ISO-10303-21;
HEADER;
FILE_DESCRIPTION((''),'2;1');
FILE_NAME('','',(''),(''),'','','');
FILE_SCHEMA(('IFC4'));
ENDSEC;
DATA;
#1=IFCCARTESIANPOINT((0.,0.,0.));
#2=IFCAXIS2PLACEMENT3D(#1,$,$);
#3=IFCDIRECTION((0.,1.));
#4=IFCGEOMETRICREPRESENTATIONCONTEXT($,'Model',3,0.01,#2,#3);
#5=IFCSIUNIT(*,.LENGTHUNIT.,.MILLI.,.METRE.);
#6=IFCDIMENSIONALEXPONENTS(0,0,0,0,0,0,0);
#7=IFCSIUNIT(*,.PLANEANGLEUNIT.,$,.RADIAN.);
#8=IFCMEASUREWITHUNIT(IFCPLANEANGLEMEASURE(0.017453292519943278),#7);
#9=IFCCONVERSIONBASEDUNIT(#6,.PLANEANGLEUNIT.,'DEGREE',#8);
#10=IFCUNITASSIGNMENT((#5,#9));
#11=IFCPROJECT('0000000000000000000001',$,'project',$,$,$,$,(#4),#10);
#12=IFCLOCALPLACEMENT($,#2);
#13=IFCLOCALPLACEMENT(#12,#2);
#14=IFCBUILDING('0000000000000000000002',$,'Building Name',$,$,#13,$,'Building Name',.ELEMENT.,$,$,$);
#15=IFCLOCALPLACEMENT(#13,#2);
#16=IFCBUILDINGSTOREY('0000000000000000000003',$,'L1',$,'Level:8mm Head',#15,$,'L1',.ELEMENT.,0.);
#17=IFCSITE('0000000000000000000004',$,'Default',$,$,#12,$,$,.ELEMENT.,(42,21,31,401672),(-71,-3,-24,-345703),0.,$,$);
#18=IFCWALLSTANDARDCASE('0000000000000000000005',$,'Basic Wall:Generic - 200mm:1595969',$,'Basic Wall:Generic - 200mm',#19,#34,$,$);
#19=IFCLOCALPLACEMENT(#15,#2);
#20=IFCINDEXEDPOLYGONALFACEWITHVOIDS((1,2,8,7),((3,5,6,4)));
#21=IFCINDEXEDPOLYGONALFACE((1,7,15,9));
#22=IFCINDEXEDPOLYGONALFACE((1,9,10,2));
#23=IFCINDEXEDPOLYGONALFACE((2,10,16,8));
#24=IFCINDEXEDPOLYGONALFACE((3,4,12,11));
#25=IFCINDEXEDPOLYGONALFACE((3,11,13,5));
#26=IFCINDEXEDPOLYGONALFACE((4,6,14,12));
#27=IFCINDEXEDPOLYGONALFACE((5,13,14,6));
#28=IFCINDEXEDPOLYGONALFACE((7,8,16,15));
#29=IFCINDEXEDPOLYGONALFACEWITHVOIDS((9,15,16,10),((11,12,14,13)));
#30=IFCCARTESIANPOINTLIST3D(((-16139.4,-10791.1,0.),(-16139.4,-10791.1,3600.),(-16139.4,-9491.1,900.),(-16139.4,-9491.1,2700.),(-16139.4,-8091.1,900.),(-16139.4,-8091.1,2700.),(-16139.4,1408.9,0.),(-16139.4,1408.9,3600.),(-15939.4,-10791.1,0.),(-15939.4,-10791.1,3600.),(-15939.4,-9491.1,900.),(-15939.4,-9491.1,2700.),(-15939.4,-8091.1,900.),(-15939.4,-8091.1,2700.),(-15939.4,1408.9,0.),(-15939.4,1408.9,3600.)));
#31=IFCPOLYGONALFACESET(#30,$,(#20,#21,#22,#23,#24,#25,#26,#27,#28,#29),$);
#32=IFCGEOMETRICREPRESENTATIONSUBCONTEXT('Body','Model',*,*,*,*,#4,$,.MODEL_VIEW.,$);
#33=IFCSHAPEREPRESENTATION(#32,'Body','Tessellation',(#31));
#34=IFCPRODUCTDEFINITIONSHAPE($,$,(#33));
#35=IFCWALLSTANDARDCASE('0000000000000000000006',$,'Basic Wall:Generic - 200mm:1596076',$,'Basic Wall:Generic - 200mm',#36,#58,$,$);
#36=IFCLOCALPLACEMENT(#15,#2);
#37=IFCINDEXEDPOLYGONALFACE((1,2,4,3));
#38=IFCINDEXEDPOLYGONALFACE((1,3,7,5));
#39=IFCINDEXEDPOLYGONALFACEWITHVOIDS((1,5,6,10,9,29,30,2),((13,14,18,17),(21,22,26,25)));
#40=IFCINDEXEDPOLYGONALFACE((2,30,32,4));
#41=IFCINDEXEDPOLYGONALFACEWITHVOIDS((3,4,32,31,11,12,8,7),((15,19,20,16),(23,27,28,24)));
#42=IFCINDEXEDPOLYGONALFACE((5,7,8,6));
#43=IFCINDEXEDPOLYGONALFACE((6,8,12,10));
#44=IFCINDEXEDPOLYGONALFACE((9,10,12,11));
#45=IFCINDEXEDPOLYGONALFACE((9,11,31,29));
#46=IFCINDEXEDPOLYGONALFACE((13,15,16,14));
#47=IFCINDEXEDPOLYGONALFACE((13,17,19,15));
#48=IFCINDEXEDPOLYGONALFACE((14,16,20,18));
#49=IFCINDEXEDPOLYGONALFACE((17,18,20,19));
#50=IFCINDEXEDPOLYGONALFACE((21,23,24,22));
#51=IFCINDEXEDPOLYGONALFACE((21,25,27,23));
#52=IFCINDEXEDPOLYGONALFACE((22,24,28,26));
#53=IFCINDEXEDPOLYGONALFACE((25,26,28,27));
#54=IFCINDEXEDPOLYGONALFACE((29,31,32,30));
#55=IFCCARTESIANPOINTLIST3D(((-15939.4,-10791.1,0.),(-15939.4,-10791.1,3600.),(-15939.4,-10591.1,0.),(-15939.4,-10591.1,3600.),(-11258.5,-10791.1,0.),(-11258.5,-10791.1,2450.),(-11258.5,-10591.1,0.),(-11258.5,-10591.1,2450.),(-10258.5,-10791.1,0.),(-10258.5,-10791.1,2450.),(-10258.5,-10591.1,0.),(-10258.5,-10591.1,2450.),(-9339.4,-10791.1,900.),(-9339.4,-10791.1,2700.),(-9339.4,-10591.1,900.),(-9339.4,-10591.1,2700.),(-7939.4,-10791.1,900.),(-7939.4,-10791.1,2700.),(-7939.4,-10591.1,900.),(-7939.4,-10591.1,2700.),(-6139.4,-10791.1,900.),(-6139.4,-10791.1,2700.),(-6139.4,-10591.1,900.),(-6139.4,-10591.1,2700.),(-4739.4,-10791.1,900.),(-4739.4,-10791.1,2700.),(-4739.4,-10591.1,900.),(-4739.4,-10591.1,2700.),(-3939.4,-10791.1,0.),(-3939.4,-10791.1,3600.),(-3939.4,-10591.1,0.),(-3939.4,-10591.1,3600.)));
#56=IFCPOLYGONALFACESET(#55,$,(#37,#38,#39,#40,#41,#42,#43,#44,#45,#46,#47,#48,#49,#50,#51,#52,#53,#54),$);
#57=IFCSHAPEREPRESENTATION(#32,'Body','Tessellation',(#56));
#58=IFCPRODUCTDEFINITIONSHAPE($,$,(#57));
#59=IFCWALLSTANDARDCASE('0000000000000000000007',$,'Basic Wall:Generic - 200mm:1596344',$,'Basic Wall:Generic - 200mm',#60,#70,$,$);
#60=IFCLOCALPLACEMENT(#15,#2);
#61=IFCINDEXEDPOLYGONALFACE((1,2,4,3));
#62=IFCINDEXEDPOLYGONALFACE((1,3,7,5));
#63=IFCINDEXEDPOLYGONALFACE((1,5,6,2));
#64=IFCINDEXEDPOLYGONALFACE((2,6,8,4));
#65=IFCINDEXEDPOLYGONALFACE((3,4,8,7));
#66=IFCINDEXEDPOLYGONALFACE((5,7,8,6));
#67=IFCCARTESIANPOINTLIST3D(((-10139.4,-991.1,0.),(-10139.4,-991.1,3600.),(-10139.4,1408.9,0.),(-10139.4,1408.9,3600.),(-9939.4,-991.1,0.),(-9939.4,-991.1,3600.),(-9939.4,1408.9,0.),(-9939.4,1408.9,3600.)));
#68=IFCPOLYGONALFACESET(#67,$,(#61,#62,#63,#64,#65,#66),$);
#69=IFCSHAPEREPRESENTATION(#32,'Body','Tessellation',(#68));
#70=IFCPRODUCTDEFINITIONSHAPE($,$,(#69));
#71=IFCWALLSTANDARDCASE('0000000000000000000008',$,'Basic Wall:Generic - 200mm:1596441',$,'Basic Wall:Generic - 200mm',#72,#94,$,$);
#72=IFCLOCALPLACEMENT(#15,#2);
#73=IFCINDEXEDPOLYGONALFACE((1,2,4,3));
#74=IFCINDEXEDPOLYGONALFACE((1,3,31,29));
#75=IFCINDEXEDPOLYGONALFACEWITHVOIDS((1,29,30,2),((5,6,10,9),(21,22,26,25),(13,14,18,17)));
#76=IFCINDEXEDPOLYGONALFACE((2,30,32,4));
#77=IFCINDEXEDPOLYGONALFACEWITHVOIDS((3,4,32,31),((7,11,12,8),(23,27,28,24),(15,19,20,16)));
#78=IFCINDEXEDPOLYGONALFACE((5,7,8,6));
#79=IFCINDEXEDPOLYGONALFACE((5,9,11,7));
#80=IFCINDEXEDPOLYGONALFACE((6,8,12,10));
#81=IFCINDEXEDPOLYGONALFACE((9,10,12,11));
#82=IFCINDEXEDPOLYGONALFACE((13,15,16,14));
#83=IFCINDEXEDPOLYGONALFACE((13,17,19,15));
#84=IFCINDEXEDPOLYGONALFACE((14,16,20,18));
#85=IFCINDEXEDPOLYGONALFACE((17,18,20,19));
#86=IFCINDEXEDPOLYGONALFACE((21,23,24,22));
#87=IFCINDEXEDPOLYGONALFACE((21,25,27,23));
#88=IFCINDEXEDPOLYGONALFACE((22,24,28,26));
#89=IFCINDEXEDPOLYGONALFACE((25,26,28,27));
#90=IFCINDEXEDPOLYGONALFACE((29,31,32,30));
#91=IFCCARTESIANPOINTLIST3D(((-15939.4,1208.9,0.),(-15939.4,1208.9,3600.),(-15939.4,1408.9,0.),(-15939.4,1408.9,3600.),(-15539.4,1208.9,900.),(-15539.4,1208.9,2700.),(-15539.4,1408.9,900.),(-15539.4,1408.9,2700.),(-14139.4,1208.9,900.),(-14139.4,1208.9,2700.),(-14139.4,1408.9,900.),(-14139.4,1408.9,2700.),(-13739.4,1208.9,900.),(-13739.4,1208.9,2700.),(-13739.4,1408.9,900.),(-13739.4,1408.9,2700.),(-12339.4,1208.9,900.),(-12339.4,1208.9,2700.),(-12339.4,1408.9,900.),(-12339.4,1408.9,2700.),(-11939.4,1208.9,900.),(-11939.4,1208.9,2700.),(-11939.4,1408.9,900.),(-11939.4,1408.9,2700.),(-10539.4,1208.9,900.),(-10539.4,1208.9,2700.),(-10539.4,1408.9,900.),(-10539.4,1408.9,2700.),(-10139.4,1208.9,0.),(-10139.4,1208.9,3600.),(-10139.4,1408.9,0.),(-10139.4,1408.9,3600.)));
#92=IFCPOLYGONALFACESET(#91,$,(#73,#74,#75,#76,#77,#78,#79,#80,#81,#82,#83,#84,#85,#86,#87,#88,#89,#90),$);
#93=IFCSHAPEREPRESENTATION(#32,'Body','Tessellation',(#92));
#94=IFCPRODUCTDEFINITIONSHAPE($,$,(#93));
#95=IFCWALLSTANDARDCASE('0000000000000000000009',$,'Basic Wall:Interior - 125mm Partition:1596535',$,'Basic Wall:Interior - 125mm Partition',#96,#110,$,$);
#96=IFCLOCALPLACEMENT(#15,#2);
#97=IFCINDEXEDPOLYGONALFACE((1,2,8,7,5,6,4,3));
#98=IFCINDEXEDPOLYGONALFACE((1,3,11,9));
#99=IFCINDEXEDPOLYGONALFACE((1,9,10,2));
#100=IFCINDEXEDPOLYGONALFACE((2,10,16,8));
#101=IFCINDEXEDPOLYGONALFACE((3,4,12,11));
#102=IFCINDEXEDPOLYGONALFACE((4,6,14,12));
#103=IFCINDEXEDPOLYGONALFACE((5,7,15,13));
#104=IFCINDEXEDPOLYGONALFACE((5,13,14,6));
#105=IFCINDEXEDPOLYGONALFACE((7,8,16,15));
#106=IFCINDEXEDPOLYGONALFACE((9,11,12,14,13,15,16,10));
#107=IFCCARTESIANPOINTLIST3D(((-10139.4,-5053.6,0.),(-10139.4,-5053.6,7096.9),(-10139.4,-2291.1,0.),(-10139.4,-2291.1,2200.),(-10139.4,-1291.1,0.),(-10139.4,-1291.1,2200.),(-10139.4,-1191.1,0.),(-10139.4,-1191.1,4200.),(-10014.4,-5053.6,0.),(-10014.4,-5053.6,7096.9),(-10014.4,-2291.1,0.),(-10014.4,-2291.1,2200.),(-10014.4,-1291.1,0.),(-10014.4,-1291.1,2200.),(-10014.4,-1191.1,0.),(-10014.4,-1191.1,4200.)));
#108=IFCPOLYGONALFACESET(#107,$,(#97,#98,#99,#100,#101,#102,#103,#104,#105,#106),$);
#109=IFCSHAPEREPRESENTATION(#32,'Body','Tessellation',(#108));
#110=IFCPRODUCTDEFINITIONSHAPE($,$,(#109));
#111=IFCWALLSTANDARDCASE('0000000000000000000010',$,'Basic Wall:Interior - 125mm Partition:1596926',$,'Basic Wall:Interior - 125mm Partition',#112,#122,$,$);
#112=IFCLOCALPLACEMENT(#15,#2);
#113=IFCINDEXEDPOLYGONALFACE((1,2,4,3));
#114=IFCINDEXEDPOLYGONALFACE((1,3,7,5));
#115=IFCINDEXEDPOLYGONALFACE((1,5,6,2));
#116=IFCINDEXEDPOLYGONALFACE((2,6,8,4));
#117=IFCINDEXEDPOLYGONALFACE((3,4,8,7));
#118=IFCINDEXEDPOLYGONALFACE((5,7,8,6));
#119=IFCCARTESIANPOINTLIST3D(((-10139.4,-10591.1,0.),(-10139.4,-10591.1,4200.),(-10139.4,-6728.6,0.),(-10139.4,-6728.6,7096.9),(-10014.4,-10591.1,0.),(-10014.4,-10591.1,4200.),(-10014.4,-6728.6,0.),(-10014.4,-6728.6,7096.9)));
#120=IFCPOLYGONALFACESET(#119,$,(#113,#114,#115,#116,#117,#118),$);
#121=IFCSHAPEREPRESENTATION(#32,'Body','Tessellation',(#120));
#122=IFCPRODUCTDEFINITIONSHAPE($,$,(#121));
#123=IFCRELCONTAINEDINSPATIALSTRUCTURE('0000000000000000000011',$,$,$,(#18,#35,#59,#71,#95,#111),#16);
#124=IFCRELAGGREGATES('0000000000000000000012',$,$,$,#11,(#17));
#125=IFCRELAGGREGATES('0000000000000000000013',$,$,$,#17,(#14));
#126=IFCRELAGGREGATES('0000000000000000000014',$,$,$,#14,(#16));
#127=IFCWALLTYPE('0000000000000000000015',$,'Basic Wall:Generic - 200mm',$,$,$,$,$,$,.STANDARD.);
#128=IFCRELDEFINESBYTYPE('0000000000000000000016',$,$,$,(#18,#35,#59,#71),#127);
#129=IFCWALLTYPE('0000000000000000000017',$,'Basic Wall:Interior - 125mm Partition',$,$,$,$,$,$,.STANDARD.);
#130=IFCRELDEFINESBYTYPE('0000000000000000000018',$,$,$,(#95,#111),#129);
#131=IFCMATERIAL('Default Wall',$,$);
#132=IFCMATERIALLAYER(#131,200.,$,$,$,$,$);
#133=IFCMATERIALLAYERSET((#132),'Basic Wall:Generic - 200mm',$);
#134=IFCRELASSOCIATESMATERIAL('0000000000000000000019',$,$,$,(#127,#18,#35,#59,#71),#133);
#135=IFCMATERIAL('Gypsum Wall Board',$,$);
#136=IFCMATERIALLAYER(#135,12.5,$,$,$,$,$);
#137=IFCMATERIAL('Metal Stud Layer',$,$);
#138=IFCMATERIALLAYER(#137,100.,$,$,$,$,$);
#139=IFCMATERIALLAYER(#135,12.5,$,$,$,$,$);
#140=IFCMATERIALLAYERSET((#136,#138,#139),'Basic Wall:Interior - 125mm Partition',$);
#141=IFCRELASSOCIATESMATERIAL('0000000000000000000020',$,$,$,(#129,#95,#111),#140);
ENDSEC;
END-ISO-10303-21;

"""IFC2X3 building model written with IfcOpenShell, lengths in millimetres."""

from ifc_helpers import new_model, entity, si_unit, converted_unit, direction, frame, frame_2d, origin, place, context, subcontext, project, spatial, polyline, rectangle, extrude, clip, bounded_halfspace, material, layer, layer_set, layer_usage, type_object, element, save


model = new_model("IFC2X3")

# Units and contexts
model_context = context("Model", 3, precision=0.01, world=origin(), true_north=direction((0.0, 1.0)))
body_context = subcontext(model_context, "Body", "Model", "MODEL_VIEW")
ifc_project = project(units=[si_unit("LENGTHUNIT", "METRE", prefix="MILLI"), converted_unit("PLANEANGLEUNIT", "DEGREE", entity("IfcPlaneAngleMeasure", 0.017453292519943278), si_unit("PLANEANGLEUNIT", "RADIAN"), dimensions=[0, 0, 0, 0, 0, 0, 0])], contexts=[model_context])

# Site, building, storey
site_placement = place(None, origin())
site = spatial("IfcSite", under=ifc_project, at=site_placement, Name="Default", CompositionType="ELEMENT", RefLatitude=(42, 21, 31, 401672), RefLongitude=(-71, -3, -24, -345703), RefElevation=0.0)
building_placement = place(site_placement, origin())
building = spatial("IfcBuilding", under=site, at=building_placement, Name="Building Name", LongName="Building Name", CompositionType="ELEMENT")
storey_placement = place(building_placement, origin())
storey = spatial("IfcBuildingStorey", under=building, at=storey_placement, Name="L1", ObjectType="Level:8mm Head", LongName="L1", CompositionType="ELEMENT", Elevation=0.0)

# Wall, opening
ifc_material_1 = material(Name="Default Wall")
ifc_layer_1 = layer(ifc_material_1, 200.0)
ifc_layer_set_1 = layer_set([ifc_layer_1], Name="Basic Wall:Generic - 200mm")
ifc_layer_usage_1 = layer_usage(ifc_layer_set_1, "AXIS2", "NEGATIVE", 100.0)
wall_type_1 = type_object("IfcWallType", Name="Basic Wall:Generic - 200mm", PredefinedType="STANDARD", material=ifc_layer_set_1)
wall_1_placement = place(storey_placement, frame((-16039.4, 1408.9, 0.0), z_axis=(0.0, 0.0, 1.0), x_axis=(0.0, -1.0, 0.0)))
wall_1 = element("IfcWallStandardCase", 1, at=wall_1_placement, inside=storey, type_object=wall_type_1, material=ifc_layer_usage_1, Name="Basic Wall:Generic - 200mm:1595969", ObjectType="Basic Wall:Generic - 200mm", context=body_context, shape_type="SweptSolid", body=[
    extrude(rectangle(XDim=12200.0, YDim=200.0, at=frame_2d((6100.0, 0.0), x_axis=(-1.0, 0.0))), origin(), (0.0, 0.0, 1.0), 3600.0),
])
opening_1_placement = place(wall_1_placement, frame((10900.0, 100.0, 900.0)))
element("IfcOpeningElement", 2, at=opening_1_placement, cuts=wall_1, ObjectType="Opening", context=body_context, shape_type="SweptSolid", body=[
    extrude(rectangle(XDim=1800.0, YDim=1400.0, at=frame_2d((900.0, 700.0), x_axis=(-1.0, 0.0))), frame((0.0, 0.0, 0.0), z_axis=(0.0, -1.0, 0.0), x_axis=(0.0, 0.0, 1.0)), (0.0, 0.0, 1.0), 200.0),
])

# Wall, openings
wall_2_placement = place(storey_placement, frame((-15939.4, -10691.1, 0.0)))
wall_2 = element("IfcWallStandardCase", 3, at=wall_2_placement, inside=storey, type_object=wall_type_1, material=ifc_layer_usage_1, Name="Basic Wall:Generic - 200mm:1596076", ObjectType="Basic Wall:Generic - 200mm", context=body_context, shape_type="SweptSolid", body=[
    extrude(rectangle(XDim=12000.0, YDim=200.0, at=frame_2d((6000.0, 0.0), x_axis=(1.0, 0.0))), origin(), (0.0, 0.0, 1.0), 3600.0),
])
opening_2_placement = place(wall_2_placement, frame((4680.9, -100.0, 0.0)))
element("IfcOpeningElement", 4, at=opening_2_placement, cuts=wall_2, ObjectType="Opening", context=body_context, shape_type="SweptSolid", body=[
    extrude(rectangle(XDim=2450.0, YDim=1000.0, at=frame_2d((1225.0, 500.0), x_axis=(1.0, 0.0))), frame((0.0, 0.0, 0.0), z_axis=(0.0, 1.0, 0.0), x_axis=(0.0, 0.0, 1.0)), (0.0, 0.0, 1.0), 200.0),
])
opening_3_placement = place(wall_2_placement, frame((11200.0, 100.0, 900.0)))
element("IfcOpeningElement", 5, at=opening_3_placement, cuts=wall_2, ObjectType="Opening", context=body_context, shape_type="SweptSolid", body=[
    extrude(rectangle(XDim=1800.0, YDim=1400.0, at=frame_2d((900.0, 700.0), x_axis=(-1.0, 0.0))), frame((0.0, 0.0, 0.0), z_axis=(0.0, -1.0, 0.0), x_axis=(0.0, 0.0, 1.0)), (0.0, 0.0, 1.0), 200.0),
])
opening_4_placement = place(wall_2_placement, frame((8000.0, 100.0, 900.0)))
element("IfcOpeningElement", 6, at=opening_4_placement, cuts=wall_2, ObjectType="Opening", context=body_context, shape_type="SweptSolid", body=[
    extrude(rectangle(XDim=1800.0, YDim=1400.0, at=frame_2d((900.0, 700.0), x_axis=(-1.0, 0.0))), frame((0.0, 0.0, 0.0), z_axis=(0.0, -1.0, 0.0), x_axis=(0.0, 0.0, 1.0)), (0.0, 0.0, 1.0), 200.0),
])

# Wall
wall_3_placement = place(storey_placement, frame((-10039.4, -991.1, 0.0), z_axis=(0.0, 0.0, 1.0), x_axis=(0.0, 1.0, 0.0)))
element("IfcWallStandardCase", 7, at=wall_3_placement, inside=storey, type_object=wall_type_1, material=ifc_layer_usage_1, Name="Basic Wall:Generic - 200mm:1596344", ObjectType="Basic Wall:Generic - 200mm", context=body_context, shape_type="SweptSolid", body=[
    extrude(rectangle(XDim=2400.0, YDim=200.0, at=frame_2d((1200.0, 0.0), x_axis=(-1.0, 0.0))), origin(), (0.0, 0.0, 1.0), 3600.0),
])

# Wall, openings
wall_4_placement = place(storey_placement, frame((-10139.4, 1308.9, 0.0), z_axis=(0.0, 0.0, 1.0), x_axis=(-1.0, 0.0, 0.0)))
wall_4 = element("IfcWallStandardCase", 8, at=wall_4_placement, inside=storey, type_object=wall_type_1, material=ifc_layer_usage_1, Name="Basic Wall:Generic - 200mm:1596441", ObjectType="Basic Wall:Generic - 200mm", context=body_context, shape_type="SweptSolid", body=[
    extrude(rectangle(XDim=5800.0, YDim=200.0, at=frame_2d((2900.0, 0.0), x_axis=(-1.0, 0.0))), origin(), (0.0, 0.0, 1.0), 3600.0),
])
opening_5_placement = place(wall_4_placement, frame((3600.0, 100.0, 900.0)))
element("IfcOpeningElement", 9, at=opening_5_placement, cuts=wall_4, ObjectType="Opening", context=body_context, shape_type="SweptSolid", body=[
    extrude(rectangle(XDim=1800.0, YDim=1400.0, at=frame_2d((900.0, 700.0), x_axis=(-1.0, 0.0))), frame((0.0, 0.0, 0.0), z_axis=(0.0, -1.0, 0.0), x_axis=(0.0, 0.0, 1.0)), (0.0, 0.0, 1.0), 200.0),
])
opening_6_placement = place(wall_4_placement, frame((1800.0, 100.0, 900.0)))
element("IfcOpeningElement", 10, at=opening_6_placement, cuts=wall_4, ObjectType="Opening", context=body_context, shape_type="SweptSolid", body=[
    extrude(rectangle(XDim=1800.0, YDim=1400.0, at=frame_2d((900.0, 700.0), x_axis=(-1.0, 0.0))), frame((0.0, 0.0, 0.0), z_axis=(0.0, -1.0, 0.0), x_axis=(0.0, 0.0, 1.0)), (0.0, 0.0, 1.0), 200.0),
])
opening_7_placement = place(wall_4_placement, frame((5400.0, 100.0, 900.0)))
element("IfcOpeningElement", 11, at=opening_7_placement, cuts=wall_4, ObjectType="Opening", context=body_context, shape_type="SweptSolid", body=[
    extrude(rectangle(XDim=1800.0, YDim=1400.0, at=frame_2d((900.0, 700.0), x_axis=(-1.0, 0.0))), frame((0.0, 0.0, 0.0), z_axis=(0.0, -1.0, 0.0), x_axis=(0.0, 0.0, 1.0)), (0.0, 0.0, 1.0), 200.0),
])

# Wall, opening
ifc_material_2 = material(Name="Gypsum Wall Board")
ifc_layer_2 = layer(ifc_material_2, 12.5)
ifc_material_3 = material(Name="Metal Stud Layer")
ifc_layer_3 = layer(ifc_material_3, 100.0)
ifc_layer_4 = layer(ifc_material_2, 12.5)
ifc_layer_set_2 = layer_set([ifc_layer_2, ifc_layer_3, ifc_layer_4], Name="Basic Wall:Interior - 125mm Partition")
ifc_layer_usage_2 = layer_usage(ifc_layer_set_2, "AXIS2", "NEGATIVE", 62.5)
wall_type_2 = type_object("IfcWallType", Name="Basic Wall:Interior - 125mm Partition", PredefinedType="STANDARD", material=ifc_layer_set_2)
wall_5_placement = place(storey_placement, frame((-10076.9, -1191.1, 0.0), z_axis=(0.0, 0.0, 1.0), x_axis=(0.0, -1.0, 0.0)))
wall_5 = element("IfcWallStandardCase", 12, at=wall_5_placement, inside=storey, type_object=wall_type_2, material=ifc_layer_usage_2, Name="Basic Wall:Interior - 125mm Partition:1596535", ObjectType="Basic Wall:Interior - 125mm Partition", context=body_context, shape_type="Clipping", body=[
    clip(extrude(rectangle(XDim=3862.5, YDim=125.0, at=frame_2d((1931.3, 0.0), x_axis=(1.0, 0.0))), origin(), (0.0, 0.0, 1.0), 7096.9), bounded_halfspace(frame((0.0, -62.5, 4200.0), z_axis=(-0.6, 0.0, 0.8), x_axis=(0.0, -1.0, 0.0)), False, frame((0.0, -62.5, 4200.0)), polyline([(0.0, 0.0), (3862.5, 0.0), (3862.5, 125.0), (3737.5, 125.0), (0.0, 125.0), (0.0, 0.0)]))),
])
opening_8_placement = place(wall_5_placement, frame((100.0, -62.5, 0.0)))
element("IfcOpeningElement", 13, at=opening_8_placement, cuts=wall_5, ObjectType="Opening", context=body_context, shape_type="SweptSolid", body=[
    extrude(rectangle(XDim=2200.0, YDim=1000.0, at=frame_2d((1100.0, 500.0), x_axis=(1.0, 0.0))), frame((0.0, 0.0, 0.0), z_axis=(0.0, 1.0, 0.0), x_axis=(0.0, 0.0, 1.0)), (0.0, 0.0, 1.0), 125.0),
])

# Wall
wall_6_placement = place(storey_placement, frame((-10076.9, -10591.1, 0.0), z_axis=(0.0, 0.0, 1.0), x_axis=(0.0, 1.0, 0.0)))
element("IfcWallStandardCase", 14, at=wall_6_placement, inside=storey, type_object=wall_type_2, material=ifc_layer_usage_2, Name="Basic Wall:Interior - 125mm Partition:1596926", ObjectType="Basic Wall:Interior - 125mm Partition", context=body_context, shape_type="Clipping", body=[
    clip(extrude(rectangle(XDim=3862.5, YDim=125.0, at=frame_2d((1931.3, 0.0), x_axis=(-1.0, 0.0))), origin(), (0.0, 0.0, 1.0), 7096.9), bounded_halfspace(frame((0.0, -62.5, 4200.0), z_axis=(-0.6, 0.0, 0.8), x_axis=(0.0, -1.0, 0.0)), False, frame((0.0, -62.5, 4200.0)), polyline([(0.0, 0.0), (3737.5, 0.0), (3862.5, 0.0), (3862.5, 125.0), (0.0, 125.0), (0.0, 0.0)]))),
])

save(model, "model.ifc")
